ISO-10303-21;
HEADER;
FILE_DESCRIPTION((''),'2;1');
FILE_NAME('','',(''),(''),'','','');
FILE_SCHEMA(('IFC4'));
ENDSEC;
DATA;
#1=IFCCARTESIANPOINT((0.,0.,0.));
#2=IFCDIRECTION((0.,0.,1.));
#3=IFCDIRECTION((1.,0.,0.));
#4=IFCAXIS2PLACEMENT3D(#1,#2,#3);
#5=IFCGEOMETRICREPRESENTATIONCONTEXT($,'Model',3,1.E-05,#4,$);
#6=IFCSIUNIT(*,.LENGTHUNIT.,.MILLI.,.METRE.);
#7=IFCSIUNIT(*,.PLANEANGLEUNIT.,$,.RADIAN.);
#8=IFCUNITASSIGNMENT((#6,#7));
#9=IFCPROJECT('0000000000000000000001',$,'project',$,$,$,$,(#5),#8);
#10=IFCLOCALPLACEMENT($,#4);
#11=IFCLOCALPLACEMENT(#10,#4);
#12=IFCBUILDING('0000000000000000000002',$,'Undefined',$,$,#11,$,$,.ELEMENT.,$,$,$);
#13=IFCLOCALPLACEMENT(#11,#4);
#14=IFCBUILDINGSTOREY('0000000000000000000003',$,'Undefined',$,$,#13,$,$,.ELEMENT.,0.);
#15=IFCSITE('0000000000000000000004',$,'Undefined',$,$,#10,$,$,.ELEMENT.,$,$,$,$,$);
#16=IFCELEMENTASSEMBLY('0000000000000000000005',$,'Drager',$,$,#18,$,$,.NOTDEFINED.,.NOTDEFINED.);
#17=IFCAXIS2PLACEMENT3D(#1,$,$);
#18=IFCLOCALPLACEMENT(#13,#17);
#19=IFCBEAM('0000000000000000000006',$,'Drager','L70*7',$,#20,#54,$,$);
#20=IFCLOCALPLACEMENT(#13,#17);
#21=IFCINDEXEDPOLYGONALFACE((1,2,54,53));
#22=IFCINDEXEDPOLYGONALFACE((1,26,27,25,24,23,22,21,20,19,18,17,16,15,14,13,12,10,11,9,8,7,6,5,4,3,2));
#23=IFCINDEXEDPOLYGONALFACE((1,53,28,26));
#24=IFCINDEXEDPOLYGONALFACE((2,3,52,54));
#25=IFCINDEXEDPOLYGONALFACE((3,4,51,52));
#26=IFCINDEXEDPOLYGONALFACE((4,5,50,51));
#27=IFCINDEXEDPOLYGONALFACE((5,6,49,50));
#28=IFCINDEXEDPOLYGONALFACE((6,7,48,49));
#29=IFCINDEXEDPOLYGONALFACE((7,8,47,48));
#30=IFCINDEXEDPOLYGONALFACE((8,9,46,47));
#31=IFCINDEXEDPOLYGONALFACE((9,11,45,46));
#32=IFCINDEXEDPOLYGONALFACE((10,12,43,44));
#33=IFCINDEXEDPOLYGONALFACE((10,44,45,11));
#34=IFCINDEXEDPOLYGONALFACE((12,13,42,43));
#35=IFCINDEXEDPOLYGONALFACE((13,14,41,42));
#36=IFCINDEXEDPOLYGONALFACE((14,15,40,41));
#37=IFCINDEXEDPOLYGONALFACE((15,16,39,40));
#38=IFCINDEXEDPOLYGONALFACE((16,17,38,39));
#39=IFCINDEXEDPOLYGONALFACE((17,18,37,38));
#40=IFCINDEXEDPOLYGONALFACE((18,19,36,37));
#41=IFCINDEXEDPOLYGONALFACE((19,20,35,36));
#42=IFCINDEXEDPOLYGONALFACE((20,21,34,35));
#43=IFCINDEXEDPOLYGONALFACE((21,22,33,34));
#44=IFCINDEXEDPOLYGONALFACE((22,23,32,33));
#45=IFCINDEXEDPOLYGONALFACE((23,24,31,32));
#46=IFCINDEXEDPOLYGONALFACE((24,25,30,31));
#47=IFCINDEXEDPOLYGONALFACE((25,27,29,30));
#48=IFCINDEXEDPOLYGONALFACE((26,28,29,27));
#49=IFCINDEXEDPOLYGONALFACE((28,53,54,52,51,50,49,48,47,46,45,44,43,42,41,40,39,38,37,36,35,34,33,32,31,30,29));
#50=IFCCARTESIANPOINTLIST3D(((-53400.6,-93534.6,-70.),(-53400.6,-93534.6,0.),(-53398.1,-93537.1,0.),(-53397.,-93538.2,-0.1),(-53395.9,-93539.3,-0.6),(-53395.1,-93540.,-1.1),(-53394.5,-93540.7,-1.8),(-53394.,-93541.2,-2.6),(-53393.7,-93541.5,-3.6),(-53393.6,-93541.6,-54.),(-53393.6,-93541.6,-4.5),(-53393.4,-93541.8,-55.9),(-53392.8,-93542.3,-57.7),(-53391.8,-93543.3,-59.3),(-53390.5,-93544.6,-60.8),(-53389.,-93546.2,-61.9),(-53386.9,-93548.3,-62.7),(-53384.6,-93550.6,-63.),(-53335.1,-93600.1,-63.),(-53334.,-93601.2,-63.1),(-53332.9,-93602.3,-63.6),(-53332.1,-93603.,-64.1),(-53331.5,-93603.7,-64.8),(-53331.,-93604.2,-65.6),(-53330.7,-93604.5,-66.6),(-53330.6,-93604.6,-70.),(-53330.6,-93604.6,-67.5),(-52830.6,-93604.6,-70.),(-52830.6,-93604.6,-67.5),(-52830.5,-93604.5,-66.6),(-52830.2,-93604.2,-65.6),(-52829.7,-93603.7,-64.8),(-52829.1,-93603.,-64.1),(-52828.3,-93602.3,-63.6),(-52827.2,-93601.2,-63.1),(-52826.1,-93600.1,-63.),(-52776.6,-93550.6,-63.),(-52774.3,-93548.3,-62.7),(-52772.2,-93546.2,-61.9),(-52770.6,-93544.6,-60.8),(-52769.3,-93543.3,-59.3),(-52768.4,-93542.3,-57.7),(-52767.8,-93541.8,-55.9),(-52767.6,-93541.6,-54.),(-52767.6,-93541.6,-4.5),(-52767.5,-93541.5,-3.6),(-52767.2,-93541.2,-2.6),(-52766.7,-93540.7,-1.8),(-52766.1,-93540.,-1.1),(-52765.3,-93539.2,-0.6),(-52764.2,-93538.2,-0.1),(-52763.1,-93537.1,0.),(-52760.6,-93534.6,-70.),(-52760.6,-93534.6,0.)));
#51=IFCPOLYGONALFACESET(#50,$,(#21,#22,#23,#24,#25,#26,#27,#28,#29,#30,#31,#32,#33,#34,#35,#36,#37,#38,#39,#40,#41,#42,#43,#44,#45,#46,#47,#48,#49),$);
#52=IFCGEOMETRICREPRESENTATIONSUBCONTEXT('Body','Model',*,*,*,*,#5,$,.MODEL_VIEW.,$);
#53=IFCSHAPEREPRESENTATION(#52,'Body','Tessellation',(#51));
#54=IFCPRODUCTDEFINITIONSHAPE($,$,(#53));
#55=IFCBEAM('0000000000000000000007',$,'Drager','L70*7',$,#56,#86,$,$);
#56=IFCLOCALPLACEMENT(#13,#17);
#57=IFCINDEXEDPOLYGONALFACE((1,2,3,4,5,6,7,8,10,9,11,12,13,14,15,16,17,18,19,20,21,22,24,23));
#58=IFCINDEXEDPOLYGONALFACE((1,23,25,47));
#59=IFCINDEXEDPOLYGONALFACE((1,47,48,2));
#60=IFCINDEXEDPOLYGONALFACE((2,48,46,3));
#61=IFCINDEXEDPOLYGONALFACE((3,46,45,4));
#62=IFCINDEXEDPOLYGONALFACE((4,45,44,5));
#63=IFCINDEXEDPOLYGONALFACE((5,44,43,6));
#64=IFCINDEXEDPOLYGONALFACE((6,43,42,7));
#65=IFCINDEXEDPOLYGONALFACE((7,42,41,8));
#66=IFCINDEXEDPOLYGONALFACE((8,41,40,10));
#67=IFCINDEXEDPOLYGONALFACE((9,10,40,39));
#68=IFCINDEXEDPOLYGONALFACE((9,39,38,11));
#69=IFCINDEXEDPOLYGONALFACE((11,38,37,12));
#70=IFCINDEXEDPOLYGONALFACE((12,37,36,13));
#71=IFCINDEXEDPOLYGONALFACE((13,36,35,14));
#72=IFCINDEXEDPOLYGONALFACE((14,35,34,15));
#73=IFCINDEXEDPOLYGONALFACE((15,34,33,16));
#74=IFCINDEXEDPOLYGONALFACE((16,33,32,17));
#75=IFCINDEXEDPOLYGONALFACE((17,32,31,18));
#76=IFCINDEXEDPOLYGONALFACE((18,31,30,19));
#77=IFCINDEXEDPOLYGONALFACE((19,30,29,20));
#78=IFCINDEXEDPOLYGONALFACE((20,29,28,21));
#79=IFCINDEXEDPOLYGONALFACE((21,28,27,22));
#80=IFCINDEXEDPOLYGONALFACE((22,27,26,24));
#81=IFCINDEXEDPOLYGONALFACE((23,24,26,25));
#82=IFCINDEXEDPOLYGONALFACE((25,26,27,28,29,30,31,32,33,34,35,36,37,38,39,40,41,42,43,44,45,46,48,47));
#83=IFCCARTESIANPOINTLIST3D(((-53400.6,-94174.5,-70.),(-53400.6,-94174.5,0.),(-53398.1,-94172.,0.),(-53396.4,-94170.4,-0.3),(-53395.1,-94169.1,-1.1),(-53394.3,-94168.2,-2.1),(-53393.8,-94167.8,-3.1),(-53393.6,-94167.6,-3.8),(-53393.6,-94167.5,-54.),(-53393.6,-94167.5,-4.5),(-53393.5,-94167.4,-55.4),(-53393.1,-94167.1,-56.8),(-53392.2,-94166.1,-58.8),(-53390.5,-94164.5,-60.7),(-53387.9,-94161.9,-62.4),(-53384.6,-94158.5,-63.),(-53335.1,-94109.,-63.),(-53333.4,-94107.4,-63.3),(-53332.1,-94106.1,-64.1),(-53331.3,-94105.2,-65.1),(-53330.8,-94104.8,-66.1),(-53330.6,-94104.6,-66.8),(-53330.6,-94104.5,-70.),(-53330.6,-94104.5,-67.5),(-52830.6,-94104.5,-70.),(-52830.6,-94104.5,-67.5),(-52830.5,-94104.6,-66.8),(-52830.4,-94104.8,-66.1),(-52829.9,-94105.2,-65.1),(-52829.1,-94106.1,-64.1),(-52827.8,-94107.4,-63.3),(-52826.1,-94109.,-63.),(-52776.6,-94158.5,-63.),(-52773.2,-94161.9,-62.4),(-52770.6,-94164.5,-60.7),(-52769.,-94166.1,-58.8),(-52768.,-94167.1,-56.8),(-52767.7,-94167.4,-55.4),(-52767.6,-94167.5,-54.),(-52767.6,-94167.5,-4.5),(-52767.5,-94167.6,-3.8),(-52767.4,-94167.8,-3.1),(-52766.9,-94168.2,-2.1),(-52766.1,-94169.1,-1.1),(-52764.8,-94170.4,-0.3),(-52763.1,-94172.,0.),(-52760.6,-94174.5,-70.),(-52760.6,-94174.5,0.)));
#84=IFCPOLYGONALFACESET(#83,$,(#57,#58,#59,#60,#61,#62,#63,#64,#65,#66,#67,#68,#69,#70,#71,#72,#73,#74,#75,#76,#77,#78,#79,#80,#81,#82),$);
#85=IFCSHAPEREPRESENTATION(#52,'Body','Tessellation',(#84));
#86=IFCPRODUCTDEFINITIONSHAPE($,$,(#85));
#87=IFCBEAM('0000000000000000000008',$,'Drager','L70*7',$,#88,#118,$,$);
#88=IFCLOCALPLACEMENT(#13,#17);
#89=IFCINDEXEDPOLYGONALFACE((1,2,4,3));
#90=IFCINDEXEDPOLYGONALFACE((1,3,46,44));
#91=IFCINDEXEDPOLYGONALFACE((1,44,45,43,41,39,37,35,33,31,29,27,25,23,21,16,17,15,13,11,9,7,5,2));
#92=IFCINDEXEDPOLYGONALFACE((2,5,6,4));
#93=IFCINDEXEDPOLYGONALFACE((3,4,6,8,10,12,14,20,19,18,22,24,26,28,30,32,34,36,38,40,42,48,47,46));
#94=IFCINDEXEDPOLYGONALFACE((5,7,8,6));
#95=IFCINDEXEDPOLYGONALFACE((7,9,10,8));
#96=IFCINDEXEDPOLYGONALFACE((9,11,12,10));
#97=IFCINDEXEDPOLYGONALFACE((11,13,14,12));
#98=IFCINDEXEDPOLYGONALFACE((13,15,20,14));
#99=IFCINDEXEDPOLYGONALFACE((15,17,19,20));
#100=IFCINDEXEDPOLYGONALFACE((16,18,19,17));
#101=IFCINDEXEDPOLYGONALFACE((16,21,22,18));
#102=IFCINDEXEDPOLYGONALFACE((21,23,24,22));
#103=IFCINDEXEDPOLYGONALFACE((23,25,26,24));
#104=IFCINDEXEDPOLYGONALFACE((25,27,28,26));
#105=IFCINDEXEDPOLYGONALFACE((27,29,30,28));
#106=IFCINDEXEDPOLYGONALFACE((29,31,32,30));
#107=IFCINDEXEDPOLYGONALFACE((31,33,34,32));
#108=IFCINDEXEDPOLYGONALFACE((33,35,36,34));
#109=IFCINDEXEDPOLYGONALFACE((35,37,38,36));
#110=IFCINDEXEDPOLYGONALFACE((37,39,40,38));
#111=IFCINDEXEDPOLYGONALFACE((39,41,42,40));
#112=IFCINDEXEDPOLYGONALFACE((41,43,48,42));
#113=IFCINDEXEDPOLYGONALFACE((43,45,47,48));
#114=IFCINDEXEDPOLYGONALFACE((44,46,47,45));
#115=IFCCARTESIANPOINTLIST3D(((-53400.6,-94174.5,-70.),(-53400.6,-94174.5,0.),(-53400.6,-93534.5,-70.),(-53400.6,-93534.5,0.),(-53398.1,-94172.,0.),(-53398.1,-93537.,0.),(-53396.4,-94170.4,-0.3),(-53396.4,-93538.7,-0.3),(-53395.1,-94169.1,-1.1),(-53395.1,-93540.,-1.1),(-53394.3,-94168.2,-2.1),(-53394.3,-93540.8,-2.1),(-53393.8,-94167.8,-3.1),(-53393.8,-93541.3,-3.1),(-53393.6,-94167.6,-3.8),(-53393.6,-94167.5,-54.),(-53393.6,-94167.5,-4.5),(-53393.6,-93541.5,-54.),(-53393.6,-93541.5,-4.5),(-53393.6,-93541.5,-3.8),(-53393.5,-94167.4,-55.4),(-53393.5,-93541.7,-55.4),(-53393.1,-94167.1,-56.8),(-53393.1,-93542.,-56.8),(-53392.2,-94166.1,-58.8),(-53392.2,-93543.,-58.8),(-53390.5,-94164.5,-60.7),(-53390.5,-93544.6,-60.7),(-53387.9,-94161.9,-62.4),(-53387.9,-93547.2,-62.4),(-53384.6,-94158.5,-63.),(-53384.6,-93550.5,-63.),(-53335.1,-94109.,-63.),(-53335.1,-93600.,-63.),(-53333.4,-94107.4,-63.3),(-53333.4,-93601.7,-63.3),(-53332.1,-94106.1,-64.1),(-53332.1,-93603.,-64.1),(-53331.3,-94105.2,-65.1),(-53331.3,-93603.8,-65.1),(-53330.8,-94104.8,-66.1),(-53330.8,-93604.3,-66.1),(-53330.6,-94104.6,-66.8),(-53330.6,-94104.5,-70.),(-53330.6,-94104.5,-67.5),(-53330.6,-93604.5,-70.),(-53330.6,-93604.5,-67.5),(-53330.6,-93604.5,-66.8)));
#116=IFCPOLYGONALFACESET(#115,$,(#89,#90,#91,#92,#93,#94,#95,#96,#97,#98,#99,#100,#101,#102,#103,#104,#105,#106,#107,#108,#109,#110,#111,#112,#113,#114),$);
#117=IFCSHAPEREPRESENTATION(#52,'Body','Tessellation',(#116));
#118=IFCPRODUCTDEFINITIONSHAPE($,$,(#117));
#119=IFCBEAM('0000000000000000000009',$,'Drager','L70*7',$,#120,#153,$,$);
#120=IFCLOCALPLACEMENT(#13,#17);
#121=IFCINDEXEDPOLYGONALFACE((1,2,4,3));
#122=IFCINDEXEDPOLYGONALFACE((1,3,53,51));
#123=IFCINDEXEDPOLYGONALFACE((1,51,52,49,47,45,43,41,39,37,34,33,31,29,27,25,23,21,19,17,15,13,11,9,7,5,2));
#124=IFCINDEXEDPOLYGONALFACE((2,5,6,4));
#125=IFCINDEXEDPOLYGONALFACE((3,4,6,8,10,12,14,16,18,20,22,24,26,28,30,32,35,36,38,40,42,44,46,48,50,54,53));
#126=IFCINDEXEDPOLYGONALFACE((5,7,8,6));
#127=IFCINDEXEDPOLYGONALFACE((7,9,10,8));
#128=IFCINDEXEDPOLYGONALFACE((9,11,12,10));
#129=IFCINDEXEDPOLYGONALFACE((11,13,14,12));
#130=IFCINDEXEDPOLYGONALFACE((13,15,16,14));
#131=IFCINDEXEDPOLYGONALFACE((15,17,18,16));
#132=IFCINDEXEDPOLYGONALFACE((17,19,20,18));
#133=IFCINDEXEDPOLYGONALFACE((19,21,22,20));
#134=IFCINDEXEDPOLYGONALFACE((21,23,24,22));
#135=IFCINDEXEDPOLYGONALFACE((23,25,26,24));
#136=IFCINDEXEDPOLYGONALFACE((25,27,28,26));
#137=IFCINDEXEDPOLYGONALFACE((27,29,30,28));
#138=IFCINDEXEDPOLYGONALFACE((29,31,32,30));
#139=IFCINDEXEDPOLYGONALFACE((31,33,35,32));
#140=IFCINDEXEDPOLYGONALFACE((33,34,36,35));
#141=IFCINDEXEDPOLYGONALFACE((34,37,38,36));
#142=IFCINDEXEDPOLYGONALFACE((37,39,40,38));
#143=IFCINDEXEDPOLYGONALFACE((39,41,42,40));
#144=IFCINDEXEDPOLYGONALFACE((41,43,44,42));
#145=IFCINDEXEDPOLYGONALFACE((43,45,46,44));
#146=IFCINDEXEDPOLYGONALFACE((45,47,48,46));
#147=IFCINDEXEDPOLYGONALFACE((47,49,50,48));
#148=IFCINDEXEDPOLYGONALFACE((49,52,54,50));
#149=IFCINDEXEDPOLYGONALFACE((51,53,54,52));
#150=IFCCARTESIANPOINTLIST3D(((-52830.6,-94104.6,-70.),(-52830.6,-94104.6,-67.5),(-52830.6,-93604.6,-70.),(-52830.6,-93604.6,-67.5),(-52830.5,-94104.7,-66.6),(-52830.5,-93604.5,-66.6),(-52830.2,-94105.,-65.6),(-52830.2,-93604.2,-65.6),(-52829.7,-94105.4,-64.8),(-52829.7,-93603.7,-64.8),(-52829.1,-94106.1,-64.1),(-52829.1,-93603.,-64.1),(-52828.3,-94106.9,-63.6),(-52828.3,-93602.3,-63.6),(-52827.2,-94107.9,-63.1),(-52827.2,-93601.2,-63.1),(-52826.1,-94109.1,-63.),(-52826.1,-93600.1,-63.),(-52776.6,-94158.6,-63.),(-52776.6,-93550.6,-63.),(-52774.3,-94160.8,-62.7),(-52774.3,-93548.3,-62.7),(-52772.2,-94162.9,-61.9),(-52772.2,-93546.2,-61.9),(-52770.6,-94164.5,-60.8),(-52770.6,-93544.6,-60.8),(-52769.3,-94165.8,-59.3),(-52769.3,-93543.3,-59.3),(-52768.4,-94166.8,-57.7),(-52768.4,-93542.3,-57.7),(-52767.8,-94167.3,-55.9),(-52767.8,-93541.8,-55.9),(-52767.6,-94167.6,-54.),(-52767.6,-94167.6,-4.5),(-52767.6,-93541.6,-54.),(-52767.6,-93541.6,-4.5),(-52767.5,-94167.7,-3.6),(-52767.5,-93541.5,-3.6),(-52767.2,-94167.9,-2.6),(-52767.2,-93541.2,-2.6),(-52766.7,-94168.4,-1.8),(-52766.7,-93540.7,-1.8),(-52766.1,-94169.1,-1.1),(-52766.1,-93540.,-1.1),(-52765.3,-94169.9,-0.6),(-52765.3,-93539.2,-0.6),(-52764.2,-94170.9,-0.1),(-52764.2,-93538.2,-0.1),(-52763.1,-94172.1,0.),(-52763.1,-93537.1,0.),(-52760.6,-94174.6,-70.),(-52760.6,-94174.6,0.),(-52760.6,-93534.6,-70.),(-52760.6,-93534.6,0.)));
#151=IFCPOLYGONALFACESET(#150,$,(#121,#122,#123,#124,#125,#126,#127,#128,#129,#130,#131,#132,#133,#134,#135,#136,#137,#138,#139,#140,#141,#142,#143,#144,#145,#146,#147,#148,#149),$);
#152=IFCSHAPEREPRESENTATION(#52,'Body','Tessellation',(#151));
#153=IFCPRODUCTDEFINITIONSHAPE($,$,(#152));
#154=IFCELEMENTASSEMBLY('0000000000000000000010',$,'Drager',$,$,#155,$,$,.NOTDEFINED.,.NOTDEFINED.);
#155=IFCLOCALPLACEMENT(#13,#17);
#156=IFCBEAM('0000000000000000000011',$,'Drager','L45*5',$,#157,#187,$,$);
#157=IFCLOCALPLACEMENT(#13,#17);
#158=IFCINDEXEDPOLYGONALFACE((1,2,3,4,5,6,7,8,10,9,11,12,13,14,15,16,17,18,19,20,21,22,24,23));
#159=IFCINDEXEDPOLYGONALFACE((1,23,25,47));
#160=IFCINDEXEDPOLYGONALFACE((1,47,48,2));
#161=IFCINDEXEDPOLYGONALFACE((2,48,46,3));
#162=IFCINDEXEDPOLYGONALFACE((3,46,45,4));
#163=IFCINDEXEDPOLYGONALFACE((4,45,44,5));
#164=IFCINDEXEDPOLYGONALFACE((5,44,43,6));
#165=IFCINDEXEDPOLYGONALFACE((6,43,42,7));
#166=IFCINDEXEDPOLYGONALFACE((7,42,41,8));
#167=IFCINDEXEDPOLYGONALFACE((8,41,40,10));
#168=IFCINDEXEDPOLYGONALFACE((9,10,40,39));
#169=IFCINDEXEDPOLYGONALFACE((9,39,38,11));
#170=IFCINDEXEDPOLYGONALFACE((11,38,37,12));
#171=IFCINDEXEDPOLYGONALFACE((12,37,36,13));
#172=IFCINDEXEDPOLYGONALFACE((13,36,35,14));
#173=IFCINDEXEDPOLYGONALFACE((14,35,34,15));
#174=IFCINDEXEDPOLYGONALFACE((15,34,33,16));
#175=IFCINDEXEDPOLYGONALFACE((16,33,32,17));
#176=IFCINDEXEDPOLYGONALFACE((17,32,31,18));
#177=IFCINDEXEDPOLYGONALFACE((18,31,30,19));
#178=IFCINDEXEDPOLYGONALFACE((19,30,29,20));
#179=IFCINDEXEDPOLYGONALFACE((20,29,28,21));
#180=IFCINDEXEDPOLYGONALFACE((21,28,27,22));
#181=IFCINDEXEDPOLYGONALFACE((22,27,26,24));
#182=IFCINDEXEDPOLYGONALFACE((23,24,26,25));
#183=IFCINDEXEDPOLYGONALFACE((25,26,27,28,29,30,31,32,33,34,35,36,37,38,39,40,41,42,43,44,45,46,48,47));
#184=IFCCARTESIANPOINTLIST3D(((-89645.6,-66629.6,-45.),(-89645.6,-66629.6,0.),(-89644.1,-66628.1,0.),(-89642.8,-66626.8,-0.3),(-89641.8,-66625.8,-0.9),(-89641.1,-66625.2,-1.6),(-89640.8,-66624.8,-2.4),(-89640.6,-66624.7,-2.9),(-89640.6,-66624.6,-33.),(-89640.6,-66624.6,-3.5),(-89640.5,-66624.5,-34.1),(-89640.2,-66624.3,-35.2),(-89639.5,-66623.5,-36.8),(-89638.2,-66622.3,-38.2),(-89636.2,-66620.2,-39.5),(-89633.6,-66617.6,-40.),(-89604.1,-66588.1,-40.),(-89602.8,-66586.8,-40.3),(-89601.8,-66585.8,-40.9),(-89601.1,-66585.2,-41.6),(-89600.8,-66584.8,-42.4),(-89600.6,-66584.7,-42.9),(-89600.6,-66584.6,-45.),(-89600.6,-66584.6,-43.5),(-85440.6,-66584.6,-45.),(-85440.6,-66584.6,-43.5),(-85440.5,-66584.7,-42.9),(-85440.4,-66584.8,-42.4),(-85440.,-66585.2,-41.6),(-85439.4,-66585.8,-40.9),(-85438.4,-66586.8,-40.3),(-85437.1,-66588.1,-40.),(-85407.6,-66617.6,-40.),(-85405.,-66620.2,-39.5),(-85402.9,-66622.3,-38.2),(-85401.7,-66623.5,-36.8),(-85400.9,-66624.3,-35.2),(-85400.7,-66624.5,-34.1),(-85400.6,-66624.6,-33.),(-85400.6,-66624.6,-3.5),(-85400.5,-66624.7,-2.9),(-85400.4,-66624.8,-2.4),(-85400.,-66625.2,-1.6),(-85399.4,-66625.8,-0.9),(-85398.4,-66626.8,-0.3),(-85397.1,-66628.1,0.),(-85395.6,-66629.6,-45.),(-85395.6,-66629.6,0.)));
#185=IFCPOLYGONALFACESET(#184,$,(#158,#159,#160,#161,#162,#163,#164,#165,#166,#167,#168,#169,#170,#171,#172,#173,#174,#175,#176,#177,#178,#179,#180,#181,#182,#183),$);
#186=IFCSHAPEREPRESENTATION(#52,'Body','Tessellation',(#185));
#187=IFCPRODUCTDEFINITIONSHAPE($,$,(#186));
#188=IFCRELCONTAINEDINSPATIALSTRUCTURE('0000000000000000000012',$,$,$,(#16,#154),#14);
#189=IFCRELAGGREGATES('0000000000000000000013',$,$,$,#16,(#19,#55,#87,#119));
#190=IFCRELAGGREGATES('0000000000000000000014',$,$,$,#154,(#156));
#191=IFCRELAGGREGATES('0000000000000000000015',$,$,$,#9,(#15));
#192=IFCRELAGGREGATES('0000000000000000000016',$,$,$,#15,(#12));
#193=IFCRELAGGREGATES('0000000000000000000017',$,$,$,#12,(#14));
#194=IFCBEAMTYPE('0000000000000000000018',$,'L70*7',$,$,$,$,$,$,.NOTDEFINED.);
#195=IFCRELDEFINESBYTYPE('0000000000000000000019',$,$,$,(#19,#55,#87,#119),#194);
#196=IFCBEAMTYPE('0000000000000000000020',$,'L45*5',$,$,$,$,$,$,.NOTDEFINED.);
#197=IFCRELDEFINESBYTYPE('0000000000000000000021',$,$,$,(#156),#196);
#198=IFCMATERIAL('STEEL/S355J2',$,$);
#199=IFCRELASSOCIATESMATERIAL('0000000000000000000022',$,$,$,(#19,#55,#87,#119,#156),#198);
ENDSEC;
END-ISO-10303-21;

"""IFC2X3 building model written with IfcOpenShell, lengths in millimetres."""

from ifc_helpers import new_model, si_unit, frame, origin_with_axes, origin_2d_with_axis, place, context, subcontext, project, spatial, l_section, extrude, clip, halfspace, material, type_object, element, aggregate, save


model = new_model("IFC2X3")

# Units and contexts
model_context = context("Model", 3, precision=1e-05, world=origin_with_axes())
body_context = subcontext(model_context, "Body", "Model", "MODEL_VIEW")
ifc_project = project(units=[si_unit("LENGTHUNIT", "METRE", prefix="MILLI"), si_unit("PLANEANGLEUNIT", "RADIAN")], contexts=[model_context])

# Site, building, storey
site_placement = place(None, origin_with_axes())
site = spatial("IfcSite", under=ifc_project, at=site_placement, Name="Undefined", CompositionType="ELEMENT")
building_placement = place(site_placement, origin_with_axes())
building = spatial("IfcBuilding", under=site, at=building_placement, Name="Undefined", CompositionType="ELEMENT")
storey_placement = place(building_placement, origin_with_axes())
storey = spatial("IfcBuildingStorey", under=building, at=storey_placement, Name="Undefined", CompositionType="ELEMENT", Elevation=0.0)

# Shared definitions
ifc_material_1 = material(Name="STEEL/S355J2")
beam_type_1 = type_object("IfcBeamType", Name="L70*7", PredefinedType="NOTDEFINED")

# Element assembly, beams
assembly_1_placement = place(storey_placement, origin_with_axes())
assembly_1 = element("IfcElementAssembly", 1, at=assembly_1_placement, inside=storey, Name="Drager", AssemblyPlace="NOTDEFINED", PredefinedType="NOTDEFINED")
beam_1_placement = place(assembly_1_placement, frame((-53330.6, -93569.6, -35.0), z_axis=(0.0, 0.0, 1.0), x_axis=(1.0, 0.000003, 0.0)))
beam_1 = element("IfcBeam", 2, at=beam_1_placement, type_object=beam_type_1, material=ifc_material_1, Name="Drager", Description="L70*7", context=body_context, shape_type="Clipping", body=[
    clip(clip(extrude(l_section(Depth=70.0, Width=70.0, Thickness=7.0, FilletRadius=9.0, EdgeRadius=4.5, at=origin_2d_with_axis()), frame((605.7, 0.0, 0.0), z_axis=(-1.0, 0.0, 0.0), x_axis=(0.0, -1.0, 0.0)), (0.0, 0.0, 1.0), 711.4), halfspace(frame((500.0, -35.0, 35.0), z_axis=(-0.707107, 0.707107, 0.0), x_axis=(0.707107, 0.707107, 0.0)), True)), halfspace(frame((0.0, -35.0, 35.0), z_axis=(-0.707107, -0.707107, 0.0), x_axis=(-0.707107, 0.707107, 0.0)), False)),
])
beam_2_placement = place(assembly_1_placement, frame((-52830.6, -94139.5, -35.0), z_axis=(0.0, 0.0, 1.0), x_axis=(-1.0, 0.0, 0.0)))
beam_2 = element("IfcBeam", 3, at=beam_2_placement, type_object=beam_type_1, material=ifc_material_1, Name="Drager", Description="L70*7", context=body_context, shape_type="Clipping", body=[
    clip(clip(extrude(l_section(Depth=70.0, Width=70.0, Thickness=7.0, FilletRadius=9.0, EdgeRadius=4.5, at=origin_2d_with_axis()), frame((605.7, 0.0, 0.0), z_axis=(-1.0, 0.0, 0.0), x_axis=(0.0, -1.0, 0.0)), (0.0, 0.0, 1.0), 711.4), halfspace(frame((500.0, -35.0, 35.0), z_axis=(0.707107, -0.707107, 0.0), x_axis=(0.0, 0.0, 1.0)), False)), halfspace(frame((0.0, -35.0, 35.0), z_axis=(0.707107, 0.707107, 0.0), x_axis=(0.0, 0.0, 1.0)), True)),
])
beam_3_placement = place(assembly_1_placement, frame((-53365.6, -94104.5, -35.0), z_axis=(0.0, 0.0, 1.0), x_axis=(0.0, 1.0, 0.0)))
beam_3 = element("IfcBeam", 4, at=beam_3_placement, type_object=beam_type_1, material=ifc_material_1, Name="Drager", Description="L70*7", context=body_context, shape_type="Clipping", body=[
    clip(clip(extrude(l_section(Depth=70.0, Width=70.0, Thickness=7.0, FilletRadius=9.0, EdgeRadius=4.5, at=origin_2d_with_axis()), frame((605.7, 0.0, 0.0), z_axis=(-1.0, 0.0, 0.0), x_axis=(0.0, -1.0, 0.0)), (0.0, 0.0, 1.0), 711.4), halfspace(frame((500.0, -35.0, 35.0), z_axis=(0.707107, -0.707107, 0.0), x_axis=(0.0, 0.0, 1.0)), False)), halfspace(frame((0.0, -35.0, 35.0), z_axis=(0.707107, 0.707107, 0.0), x_axis=(0.0, 0.0, 1.0)), True)),
])
beam_4_placement = place(assembly_1_placement, frame((-52795.6, -93604.6, -35.0), z_axis=(0.0, 0.0, 1.0), x_axis=(0.000002, -1.0, 0.0)))
beam_4 = element("IfcBeam", 5, at=beam_4_placement, type_object=beam_type_1, material=ifc_material_1, Name="Drager", Description="L70*7", context=body_context, shape_type="Clipping", body=[
    clip(clip(extrude(l_section(Depth=70.0, Width=70.0, Thickness=7.0, FilletRadius=9.0, EdgeRadius=4.5, at=origin_2d_with_axis()), frame((605.7, 0.0, 0.0), z_axis=(-1.0, 0.0, 0.0), x_axis=(0.0, -1.0, 0.0)), (0.0, 0.0, 1.0), 711.4), halfspace(frame((500.0, -35.0, 35.0), z_axis=(-0.707107, 0.707107, 0.0), x_axis=(0.707107, 0.707107, 0.0)), True)), halfspace(frame((0.0, -35.0, 35.0), z_axis=(-0.707107, -0.707107, 0.0), x_axis=(-0.707107, 0.707107, 0.0)), False)),
])
aggregate(assembly_1, [beam_1, beam_2, beam_3, beam_4])

# Element assembly, beam
assembly_2_placement = place(storey_placement, origin_with_axes())
assembly_2 = element("IfcElementAssembly", 6, at=assembly_2_placement, inside=storey, Name="Drager", AssemblyPlace="NOTDEFINED", PredefinedType="NOTDEFINED")
beam_type_2 = type_object("IfcBeamType", Name="L45*5", PredefinedType="NOTDEFINED")
beam_5_placement = place(assembly_2_placement, frame((-85440.6, -66607.1, -22.5), z_axis=(0.0, 0.0, 1.0), x_axis=(-1.0, 0.0, 0.0)))
beam_5 = element("IfcBeam", 7, at=beam_5_placement, type_object=beam_type_2, material=ifc_material_1, Name="Drager", Description="L45*5", context=body_context, shape_type="Clipping", body=[
    clip(clip(extrude(l_section(Depth=45.0, Width=45.0, Thickness=5.0, FilletRadius=7.0, EdgeRadius=3.5, at=origin_2d_with_axis()), frame((4227.9, 0.0, 0.0), z_axis=(-1.0, 0.0, 0.0), x_axis=(0.0, -1.0, 0.0)), (0.0, 0.0, 1.0), 4295.9), halfspace(frame((4160.0, -22.5, 22.5), z_axis=(0.707107, -0.707107, 0.0), x_axis=(0.0, 0.0, 1.0)), False)), halfspace(frame((0.0, -22.5, 22.5), z_axis=(0.707107, 0.707107, 0.0), x_axis=(0.0, 0.0, 1.0)), True)),
])
aggregate(assembly_2, [beam_5])

save(model, "model.ifc")
